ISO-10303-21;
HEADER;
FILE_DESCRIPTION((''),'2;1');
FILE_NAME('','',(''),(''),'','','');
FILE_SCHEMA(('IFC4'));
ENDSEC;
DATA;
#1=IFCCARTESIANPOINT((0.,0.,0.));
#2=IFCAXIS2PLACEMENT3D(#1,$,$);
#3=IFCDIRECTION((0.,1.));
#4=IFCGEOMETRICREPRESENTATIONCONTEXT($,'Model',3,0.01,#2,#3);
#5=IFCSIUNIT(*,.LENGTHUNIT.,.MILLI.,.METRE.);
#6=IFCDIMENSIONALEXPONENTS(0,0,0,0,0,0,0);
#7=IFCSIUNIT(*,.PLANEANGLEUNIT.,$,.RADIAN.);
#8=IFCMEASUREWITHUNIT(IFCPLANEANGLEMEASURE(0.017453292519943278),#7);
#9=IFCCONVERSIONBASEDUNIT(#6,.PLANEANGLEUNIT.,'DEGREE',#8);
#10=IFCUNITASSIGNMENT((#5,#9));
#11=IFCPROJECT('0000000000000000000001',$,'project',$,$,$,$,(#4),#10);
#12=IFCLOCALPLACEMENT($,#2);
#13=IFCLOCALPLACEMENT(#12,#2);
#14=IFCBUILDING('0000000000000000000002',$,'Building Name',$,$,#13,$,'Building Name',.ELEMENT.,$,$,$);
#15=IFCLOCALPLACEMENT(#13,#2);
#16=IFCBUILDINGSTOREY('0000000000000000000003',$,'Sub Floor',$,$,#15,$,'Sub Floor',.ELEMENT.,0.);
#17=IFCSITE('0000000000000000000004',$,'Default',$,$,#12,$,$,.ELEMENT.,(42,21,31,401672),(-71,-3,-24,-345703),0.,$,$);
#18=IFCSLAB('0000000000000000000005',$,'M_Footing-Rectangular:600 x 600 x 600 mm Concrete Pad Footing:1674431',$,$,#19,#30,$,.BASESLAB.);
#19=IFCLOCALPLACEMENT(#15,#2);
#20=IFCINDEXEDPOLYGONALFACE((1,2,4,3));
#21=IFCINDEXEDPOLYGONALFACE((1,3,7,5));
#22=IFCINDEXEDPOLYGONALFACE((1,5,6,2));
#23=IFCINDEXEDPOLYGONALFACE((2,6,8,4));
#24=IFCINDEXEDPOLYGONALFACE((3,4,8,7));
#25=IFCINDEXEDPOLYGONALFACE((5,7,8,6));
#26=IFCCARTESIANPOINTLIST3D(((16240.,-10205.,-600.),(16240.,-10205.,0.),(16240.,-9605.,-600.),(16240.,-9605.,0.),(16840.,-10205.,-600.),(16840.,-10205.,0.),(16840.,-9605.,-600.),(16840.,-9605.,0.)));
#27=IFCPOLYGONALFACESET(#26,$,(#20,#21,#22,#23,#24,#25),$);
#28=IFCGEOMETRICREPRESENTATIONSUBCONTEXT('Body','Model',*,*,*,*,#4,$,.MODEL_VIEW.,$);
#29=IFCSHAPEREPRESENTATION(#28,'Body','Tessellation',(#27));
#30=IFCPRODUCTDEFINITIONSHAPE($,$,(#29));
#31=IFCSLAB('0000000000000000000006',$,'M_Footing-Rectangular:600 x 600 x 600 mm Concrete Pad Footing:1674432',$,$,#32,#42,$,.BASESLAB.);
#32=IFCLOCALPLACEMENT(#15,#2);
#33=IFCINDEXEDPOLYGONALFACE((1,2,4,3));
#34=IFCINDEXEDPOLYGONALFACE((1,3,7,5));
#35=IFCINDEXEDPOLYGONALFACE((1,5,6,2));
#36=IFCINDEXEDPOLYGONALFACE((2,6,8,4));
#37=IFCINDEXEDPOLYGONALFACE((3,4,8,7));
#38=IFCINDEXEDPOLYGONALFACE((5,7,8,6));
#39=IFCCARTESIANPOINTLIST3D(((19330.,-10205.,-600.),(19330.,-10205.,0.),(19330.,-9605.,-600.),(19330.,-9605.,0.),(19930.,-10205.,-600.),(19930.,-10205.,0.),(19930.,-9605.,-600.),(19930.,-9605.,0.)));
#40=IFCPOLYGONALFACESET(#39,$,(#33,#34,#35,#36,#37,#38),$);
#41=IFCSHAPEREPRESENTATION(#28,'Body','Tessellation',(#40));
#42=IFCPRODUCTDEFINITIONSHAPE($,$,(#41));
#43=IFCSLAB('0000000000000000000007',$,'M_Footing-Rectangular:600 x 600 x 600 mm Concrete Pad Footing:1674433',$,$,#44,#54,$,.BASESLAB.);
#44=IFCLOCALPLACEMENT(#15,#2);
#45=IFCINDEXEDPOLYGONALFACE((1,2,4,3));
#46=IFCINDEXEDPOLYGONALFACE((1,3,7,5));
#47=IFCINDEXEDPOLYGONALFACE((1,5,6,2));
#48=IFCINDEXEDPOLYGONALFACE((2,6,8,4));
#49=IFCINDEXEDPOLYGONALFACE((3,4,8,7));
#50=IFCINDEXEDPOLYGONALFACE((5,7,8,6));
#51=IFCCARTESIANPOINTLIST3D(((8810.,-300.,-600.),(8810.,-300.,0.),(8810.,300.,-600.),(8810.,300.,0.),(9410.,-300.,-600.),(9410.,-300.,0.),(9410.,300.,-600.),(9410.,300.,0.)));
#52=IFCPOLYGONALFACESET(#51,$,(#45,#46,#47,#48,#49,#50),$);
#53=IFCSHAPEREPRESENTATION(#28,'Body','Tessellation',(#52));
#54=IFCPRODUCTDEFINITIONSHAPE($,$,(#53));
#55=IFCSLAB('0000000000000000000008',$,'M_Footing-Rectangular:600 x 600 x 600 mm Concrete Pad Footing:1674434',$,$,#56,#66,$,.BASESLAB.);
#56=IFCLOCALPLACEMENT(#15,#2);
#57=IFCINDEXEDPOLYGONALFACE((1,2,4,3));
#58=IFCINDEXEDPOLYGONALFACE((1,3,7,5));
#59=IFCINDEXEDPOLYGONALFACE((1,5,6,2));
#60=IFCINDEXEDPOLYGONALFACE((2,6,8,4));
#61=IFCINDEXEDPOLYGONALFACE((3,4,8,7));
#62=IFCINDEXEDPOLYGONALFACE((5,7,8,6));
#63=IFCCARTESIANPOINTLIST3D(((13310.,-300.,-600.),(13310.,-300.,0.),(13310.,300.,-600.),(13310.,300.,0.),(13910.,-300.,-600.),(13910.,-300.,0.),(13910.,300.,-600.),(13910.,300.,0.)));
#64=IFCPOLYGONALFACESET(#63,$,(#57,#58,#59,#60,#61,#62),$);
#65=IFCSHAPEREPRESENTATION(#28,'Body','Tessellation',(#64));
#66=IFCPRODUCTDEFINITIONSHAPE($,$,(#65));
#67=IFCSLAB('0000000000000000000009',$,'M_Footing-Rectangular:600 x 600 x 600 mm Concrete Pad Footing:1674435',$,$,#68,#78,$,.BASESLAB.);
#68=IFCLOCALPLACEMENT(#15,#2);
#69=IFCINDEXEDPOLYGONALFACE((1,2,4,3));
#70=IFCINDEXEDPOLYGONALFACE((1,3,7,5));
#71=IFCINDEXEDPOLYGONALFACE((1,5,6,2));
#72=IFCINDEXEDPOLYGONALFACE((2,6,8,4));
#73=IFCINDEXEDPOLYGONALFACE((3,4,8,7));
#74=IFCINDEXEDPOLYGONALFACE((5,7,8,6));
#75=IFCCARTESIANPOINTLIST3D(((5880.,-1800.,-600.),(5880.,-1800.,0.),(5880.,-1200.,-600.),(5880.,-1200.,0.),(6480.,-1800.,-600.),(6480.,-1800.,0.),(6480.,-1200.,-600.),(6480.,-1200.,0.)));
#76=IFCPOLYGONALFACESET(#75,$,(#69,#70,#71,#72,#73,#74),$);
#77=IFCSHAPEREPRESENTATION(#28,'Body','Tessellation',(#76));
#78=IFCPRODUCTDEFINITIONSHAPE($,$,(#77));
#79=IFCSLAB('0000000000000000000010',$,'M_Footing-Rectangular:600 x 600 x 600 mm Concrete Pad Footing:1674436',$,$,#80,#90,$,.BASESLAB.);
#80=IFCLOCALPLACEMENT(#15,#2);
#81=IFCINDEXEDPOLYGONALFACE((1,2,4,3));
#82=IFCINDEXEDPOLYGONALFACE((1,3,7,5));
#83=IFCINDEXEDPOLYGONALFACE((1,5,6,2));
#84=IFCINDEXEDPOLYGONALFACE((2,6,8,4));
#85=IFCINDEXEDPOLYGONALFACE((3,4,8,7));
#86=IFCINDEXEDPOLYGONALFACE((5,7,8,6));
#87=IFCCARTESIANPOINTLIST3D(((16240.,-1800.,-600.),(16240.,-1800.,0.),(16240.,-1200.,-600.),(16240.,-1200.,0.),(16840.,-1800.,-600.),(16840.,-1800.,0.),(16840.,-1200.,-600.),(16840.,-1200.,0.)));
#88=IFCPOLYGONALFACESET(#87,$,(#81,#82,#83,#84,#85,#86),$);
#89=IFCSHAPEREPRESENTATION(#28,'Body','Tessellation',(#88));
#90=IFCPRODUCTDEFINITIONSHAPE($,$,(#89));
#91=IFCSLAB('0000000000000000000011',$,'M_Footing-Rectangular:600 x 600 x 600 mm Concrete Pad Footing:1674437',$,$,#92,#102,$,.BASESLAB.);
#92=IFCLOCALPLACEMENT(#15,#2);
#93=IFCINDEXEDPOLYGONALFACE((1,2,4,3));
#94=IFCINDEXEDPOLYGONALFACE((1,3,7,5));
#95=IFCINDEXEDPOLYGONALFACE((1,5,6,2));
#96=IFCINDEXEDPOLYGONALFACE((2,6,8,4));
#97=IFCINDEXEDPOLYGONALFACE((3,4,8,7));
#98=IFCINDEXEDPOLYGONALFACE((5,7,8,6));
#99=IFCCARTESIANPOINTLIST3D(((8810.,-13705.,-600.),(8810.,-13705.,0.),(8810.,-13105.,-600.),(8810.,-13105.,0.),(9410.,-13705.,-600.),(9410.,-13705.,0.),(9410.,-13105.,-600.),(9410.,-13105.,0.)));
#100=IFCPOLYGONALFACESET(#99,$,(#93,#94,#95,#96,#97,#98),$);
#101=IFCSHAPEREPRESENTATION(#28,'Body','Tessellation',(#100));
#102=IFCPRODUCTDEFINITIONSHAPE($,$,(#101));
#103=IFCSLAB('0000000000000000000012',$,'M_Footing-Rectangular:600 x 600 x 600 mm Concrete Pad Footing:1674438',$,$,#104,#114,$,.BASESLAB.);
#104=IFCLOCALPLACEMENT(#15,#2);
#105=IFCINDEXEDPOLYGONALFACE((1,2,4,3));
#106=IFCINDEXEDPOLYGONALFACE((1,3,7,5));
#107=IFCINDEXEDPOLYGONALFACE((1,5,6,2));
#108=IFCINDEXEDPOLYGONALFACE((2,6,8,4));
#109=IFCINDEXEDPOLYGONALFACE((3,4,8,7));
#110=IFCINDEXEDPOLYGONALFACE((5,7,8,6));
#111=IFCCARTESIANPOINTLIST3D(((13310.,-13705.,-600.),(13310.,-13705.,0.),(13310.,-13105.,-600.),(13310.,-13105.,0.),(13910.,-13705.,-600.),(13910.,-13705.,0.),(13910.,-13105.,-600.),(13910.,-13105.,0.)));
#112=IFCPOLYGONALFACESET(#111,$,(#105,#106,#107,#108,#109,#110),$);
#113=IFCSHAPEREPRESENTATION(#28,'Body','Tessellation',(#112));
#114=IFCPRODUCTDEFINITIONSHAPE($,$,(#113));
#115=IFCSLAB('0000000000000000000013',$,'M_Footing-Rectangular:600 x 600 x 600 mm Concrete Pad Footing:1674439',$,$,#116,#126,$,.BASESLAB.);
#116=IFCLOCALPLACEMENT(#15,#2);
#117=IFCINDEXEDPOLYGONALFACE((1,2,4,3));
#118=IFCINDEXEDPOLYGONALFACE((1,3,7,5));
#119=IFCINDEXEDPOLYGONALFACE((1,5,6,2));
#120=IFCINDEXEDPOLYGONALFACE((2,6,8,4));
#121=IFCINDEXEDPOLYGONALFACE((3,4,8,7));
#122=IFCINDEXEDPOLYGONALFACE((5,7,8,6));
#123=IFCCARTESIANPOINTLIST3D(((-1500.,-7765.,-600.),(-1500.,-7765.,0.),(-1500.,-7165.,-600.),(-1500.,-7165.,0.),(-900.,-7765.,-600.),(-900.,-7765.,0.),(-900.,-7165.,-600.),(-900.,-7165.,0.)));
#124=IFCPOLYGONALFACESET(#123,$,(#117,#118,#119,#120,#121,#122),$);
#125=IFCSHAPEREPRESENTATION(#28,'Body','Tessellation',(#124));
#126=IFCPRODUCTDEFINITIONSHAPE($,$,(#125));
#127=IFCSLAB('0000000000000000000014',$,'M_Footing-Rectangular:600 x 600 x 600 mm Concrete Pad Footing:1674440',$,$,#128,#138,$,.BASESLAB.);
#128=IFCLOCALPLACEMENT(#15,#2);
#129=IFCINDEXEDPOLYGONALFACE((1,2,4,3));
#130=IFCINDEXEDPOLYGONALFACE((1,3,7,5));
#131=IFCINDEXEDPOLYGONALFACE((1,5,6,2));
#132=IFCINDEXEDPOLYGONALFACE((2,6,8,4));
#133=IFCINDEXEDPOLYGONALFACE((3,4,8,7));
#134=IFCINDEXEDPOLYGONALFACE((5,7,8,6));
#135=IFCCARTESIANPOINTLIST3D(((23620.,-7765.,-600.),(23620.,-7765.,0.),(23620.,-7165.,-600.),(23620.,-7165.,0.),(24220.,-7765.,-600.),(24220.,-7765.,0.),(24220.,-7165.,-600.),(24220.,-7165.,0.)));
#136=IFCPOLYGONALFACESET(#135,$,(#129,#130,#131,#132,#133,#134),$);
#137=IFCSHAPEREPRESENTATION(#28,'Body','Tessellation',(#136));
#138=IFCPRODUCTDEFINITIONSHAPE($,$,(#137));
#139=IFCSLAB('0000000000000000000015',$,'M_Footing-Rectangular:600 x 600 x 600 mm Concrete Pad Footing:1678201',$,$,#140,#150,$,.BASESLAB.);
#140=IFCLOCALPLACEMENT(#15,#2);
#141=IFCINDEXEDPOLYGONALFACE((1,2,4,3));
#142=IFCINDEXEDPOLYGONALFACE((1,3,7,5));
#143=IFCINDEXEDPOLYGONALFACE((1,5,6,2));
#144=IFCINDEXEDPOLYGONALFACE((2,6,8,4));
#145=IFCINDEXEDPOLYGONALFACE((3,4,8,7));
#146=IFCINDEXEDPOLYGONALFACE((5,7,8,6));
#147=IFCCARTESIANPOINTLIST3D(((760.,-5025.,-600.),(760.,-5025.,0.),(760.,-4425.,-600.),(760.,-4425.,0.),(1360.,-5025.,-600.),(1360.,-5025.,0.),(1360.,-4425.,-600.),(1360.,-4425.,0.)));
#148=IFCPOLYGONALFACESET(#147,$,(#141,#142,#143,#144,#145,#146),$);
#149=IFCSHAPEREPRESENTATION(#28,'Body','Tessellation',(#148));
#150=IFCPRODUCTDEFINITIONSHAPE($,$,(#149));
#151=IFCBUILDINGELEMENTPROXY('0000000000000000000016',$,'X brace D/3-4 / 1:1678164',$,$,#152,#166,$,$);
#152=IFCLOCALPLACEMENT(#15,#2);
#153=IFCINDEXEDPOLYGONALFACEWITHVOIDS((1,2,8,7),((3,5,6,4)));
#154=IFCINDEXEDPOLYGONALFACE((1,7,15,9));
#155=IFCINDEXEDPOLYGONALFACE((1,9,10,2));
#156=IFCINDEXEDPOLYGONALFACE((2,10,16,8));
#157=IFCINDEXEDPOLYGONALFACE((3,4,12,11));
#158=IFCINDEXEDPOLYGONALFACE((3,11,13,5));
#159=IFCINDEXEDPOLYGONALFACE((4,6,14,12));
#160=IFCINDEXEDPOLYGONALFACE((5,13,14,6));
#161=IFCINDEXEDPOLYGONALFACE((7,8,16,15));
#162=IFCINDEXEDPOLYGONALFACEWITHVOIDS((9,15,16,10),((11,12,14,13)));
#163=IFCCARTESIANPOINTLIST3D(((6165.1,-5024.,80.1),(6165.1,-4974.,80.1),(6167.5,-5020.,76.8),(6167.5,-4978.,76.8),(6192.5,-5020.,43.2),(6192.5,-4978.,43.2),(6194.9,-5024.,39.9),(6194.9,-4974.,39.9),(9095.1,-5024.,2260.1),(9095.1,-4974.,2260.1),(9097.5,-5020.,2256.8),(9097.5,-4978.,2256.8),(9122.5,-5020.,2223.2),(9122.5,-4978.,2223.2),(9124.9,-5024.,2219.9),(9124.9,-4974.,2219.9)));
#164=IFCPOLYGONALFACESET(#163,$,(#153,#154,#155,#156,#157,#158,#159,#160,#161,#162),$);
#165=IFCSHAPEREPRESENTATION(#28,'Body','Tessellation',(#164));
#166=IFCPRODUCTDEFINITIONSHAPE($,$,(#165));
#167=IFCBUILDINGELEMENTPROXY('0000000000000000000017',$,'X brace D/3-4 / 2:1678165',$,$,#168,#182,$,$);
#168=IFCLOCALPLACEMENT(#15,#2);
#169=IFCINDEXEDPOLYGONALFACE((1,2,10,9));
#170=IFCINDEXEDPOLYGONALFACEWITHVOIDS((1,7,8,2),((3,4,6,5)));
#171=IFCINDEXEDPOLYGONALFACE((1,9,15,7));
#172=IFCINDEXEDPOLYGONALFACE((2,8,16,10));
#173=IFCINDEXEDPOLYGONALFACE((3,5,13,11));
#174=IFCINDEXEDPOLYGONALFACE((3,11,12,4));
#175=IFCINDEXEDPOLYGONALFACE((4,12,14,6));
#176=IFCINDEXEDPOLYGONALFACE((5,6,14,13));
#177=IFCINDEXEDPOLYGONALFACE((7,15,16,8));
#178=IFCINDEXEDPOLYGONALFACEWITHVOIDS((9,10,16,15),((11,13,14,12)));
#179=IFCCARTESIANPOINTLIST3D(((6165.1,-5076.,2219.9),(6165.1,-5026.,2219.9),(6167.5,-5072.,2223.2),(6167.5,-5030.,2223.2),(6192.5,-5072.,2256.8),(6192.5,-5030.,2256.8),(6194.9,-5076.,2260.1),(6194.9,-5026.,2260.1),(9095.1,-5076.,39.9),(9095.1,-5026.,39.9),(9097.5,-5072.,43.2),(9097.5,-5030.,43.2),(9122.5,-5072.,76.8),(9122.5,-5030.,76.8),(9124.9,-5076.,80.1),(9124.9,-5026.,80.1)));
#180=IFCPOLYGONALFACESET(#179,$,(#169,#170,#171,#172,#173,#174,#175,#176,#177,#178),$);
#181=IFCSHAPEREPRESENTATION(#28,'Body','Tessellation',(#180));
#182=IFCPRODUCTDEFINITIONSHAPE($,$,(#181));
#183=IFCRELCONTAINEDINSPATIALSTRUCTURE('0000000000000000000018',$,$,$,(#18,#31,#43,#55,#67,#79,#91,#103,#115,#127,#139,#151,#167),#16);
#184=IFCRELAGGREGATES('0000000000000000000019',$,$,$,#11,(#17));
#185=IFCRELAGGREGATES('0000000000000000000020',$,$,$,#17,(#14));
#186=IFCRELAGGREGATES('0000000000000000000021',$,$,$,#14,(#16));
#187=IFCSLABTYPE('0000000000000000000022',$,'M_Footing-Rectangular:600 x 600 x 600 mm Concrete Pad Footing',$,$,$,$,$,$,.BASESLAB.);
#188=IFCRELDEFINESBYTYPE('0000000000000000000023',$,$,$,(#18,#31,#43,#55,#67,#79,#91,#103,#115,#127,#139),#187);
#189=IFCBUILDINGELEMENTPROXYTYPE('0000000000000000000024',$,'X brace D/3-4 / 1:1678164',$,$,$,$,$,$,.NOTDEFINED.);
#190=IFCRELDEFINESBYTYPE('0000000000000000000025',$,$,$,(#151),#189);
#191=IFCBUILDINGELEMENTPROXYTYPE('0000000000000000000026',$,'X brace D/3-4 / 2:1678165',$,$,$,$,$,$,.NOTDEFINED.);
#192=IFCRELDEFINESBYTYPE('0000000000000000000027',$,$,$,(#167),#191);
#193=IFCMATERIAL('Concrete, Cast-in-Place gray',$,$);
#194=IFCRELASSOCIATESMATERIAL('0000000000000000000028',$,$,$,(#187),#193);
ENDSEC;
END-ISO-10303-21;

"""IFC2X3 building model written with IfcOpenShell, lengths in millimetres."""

from ifc_helpers import new_model, entity, si_unit, converted_unit, direction, frame, frame_2d, origin, origin_2d_with_axis, place, context, subcontext, project, spatial, polyline, rectangle, outline, extrude, material, type_object, element, save


model = new_model("IFC2X3")

# Units and contexts
model_context = context("Model", 3, precision=0.01, world=origin(), true_north=direction((0.0, 1.0)))
body_context = subcontext(model_context, "Body", "Model", "MODEL_VIEW")
ifc_project = project(units=[si_unit("LENGTHUNIT", "METRE", prefix="MILLI"), converted_unit("PLANEANGLEUNIT", "DEGREE", entity("IfcPlaneAngleMeasure", 0.017453292519943278), si_unit("PLANEANGLEUNIT", "RADIAN"), dimensions=[0, 0, 0, 0, 0, 0, 0])], contexts=[model_context])

# Site, building, storey
site_placement = place(None, origin())
site = spatial("IfcSite", under=ifc_project, at=site_placement, Name="Default", CompositionType="ELEMENT", RefLatitude=(42, 21, 31, 401672), RefLongitude=(-71, -3, -24, -345703), RefElevation=0.0)
building_placement = place(site_placement, origin())
building = spatial("IfcBuilding", under=site, at=building_placement, Name="Building Name", LongName="Building Name", CompositionType="ELEMENT")
storey_placement = place(building_placement, origin())
storey = spatial("IfcBuildingStorey", under=building, at=storey_placement, Name="Sub Floor", LongName="Sub Floor", CompositionType="ELEMENT", Elevation=0.0)

# Slabs
ifc_material_1 = material(Name="Concrete, Cast-in-Place gray")
slab_type_1 = type_object("IfcSlabType", Name="M_Footing-Rectangular:600 x 600 x 600 mm Concrete Pad Footing", PredefinedType="BASESLAB", material=ifc_material_1)
slab_1_placement = place(storey_placement, origin())
element("IfcSlab", 1, at=slab_1_placement, inside=storey, type_object=slab_type_1, Name="M_Footing-Rectangular:600 x 600 x 600 mm Concrete Pad Footing:1674431", PredefinedType="BASESLAB", context=body_context, shape_type="SweptSolid", body=[
    extrude(rectangle(XDim=600.0, YDim=600.0, at=frame_2d((0.0, 0.0), x_axis=(1.0, 0.0))), frame((16540.0, -9905.0, -600.0), z_axis=(0.0, 0.0, 1.0), x_axis=(-1.0, 0.0, 0.0)), (0.0, 0.0, 1.0), 600.0),
])
slab_2_placement = place(storey_placement, origin())
element("IfcSlab", 2, at=slab_2_placement, inside=storey, type_object=slab_type_1, Name="M_Footing-Rectangular:600 x 600 x 600 mm Concrete Pad Footing:1674432", PredefinedType="BASESLAB", context=body_context, shape_type="SweptSolid", body=[
    extrude(rectangle(XDim=600.0, YDim=600.0, at=frame_2d((0.0, 0.0), x_axis=(1.0, 0.0))), frame((19630.0, -9905.0, -600.0), z_axis=(0.0, 0.0, 1.0), x_axis=(-1.0, 0.0, 0.0)), (0.0, 0.0, 1.0), 600.0),
])
slab_3_placement = place(storey_placement, origin())
element("IfcSlab", 3, at=slab_3_placement, inside=storey, type_object=slab_type_1, Name="M_Footing-Rectangular:600 x 600 x 600 mm Concrete Pad Footing:1674433", PredefinedType="BASESLAB", context=body_context, shape_type="SweptSolid", body=[
    extrude(rectangle(XDim=600.0, YDim=600.0, at=origin_2d_with_axis()), frame((9110.0, 0.0, -600.0), z_axis=(0.0, 0.0, 1.0), x_axis=(-1.0, 0.0, 0.0)), (0.0, 0.0, 1.0), 600.0),
])
slab_4_placement = place(storey_placement, origin())
element("IfcSlab", 4, at=slab_4_placement, inside=storey, type_object=slab_type_1, Name="M_Footing-Rectangular:600 x 600 x 600 mm Concrete Pad Footing:1674434", PredefinedType="BASESLAB", context=body_context, shape_type="SweptSolid", body=[
    extrude(rectangle(XDim=600.0, YDim=600.0, at=frame_2d((0.0, 0.0), x_axis=(1.0, 0.0))), frame((13610.0, 0.0, -600.0), z_axis=(0.0, 0.0, 1.0), x_axis=(-1.0, 0.0, 0.0)), (0.0, 0.0, 1.0), 600.0),
])
slab_5_placement = place(storey_placement, origin())
element("IfcSlab", 5, at=slab_5_placement, inside=storey, type_object=slab_type_1, Name="M_Footing-Rectangular:600 x 600 x 600 mm Concrete Pad Footing:1674435", PredefinedType="BASESLAB", context=body_context, shape_type="SweptSolid", body=[
    extrude(rectangle(XDim=600.0, YDim=600.0, at=origin_2d_with_axis()), frame((6180.0, -1500.0, -600.0), z_axis=(0.0, 0.0, 1.0), x_axis=(-1.0, 0.0, 0.0)), (0.0, 0.0, 1.0), 600.0),
])
slab_6_placement = place(storey_placement, origin())
element("IfcSlab", 6, at=slab_6_placement, inside=storey, type_object=slab_type_1, Name="M_Footing-Rectangular:600 x 600 x 600 mm Concrete Pad Footing:1674436", PredefinedType="BASESLAB", context=body_context, shape_type="SweptSolid", body=[
    extrude(rectangle(XDim=600.0, YDim=600.0, at=frame_2d((0.0, 0.0), x_axis=(1.0, 0.0))), frame((16540.0, -1500.0, -600.0), z_axis=(0.0, 0.0, 1.0), x_axis=(-1.0, 0.0, 0.0)), (0.0, 0.0, 1.0), 600.0),
])
slab_7_placement = place(storey_placement, origin())
element("IfcSlab", 7, at=slab_7_placement, inside=storey, type_object=slab_type_1, Name="M_Footing-Rectangular:600 x 600 x 600 mm Concrete Pad Footing:1674437", PredefinedType="BASESLAB", context=body_context, shape_type="SweptSolid", body=[
    extrude(rectangle(XDim=600.0, YDim=600.0, at=frame_2d((0.0, 0.0), x_axis=(1.0, 0.0))), frame((9110.0, -13405.0, -600.0), z_axis=(0.0, 0.0, 1.0), x_axis=(-1.0, 0.0, 0.0)), (0.0, 0.0, 1.0), 600.0),
])
slab_8_placement = place(storey_placement, origin())
element("IfcSlab", 8, at=slab_8_placement, inside=storey, type_object=slab_type_1, Name="M_Footing-Rectangular:600 x 600 x 600 mm Concrete Pad Footing:1674438", PredefinedType="BASESLAB", context=body_context, shape_type="SweptSolid", body=[
    extrude(rectangle(XDim=600.0, YDim=600.0, at=frame_2d((0.0, 0.0), x_axis=(1.0, 0.0))), frame((13610.0, -13405.0, -600.0), z_axis=(0.0, 0.0, 1.0), x_axis=(-1.0, 0.0, 0.0)), (0.0, 0.0, 1.0), 600.0),
])
slab_9_placement = place(storey_placement, origin())
element("IfcSlab", 9, at=slab_9_placement, inside=storey, type_object=slab_type_1, Name="M_Footing-Rectangular:600 x 600 x 600 mm Concrete Pad Footing:1674439", PredefinedType="BASESLAB", context=body_context, shape_type="SweptSolid", body=[
    extrude(rectangle(XDim=600.0, YDim=600.0, at=origin_2d_with_axis()), frame((-1200.0, -7465.0, -600.0), z_axis=(0.0, 0.0, 1.0), x_axis=(-1.0, 0.0, 0.0)), (0.0, 0.0, 1.0), 600.0),
])
slab_10_placement = place(storey_placement, origin())
element("IfcSlab", 10, at=slab_10_placement, inside=storey, type_object=slab_type_1, Name="M_Footing-Rectangular:600 x 600 x 600 mm Concrete Pad Footing:1674440", PredefinedType="BASESLAB", context=body_context, shape_type="SweptSolid", body=[
    extrude(rectangle(XDim=600.0, YDim=600.0, at=frame_2d((0.0, 0.0), x_axis=(1.0, 0.0))), frame((23920.0, -7465.0, -600.0), z_axis=(0.0, 0.0, 1.0), x_axis=(-1.0, 0.0, 0.0)), (0.0, 0.0, 1.0), 600.0),
])
slab_11_placement = place(storey_placement, origin())
element("IfcSlab", 11, at=slab_11_placement, inside=storey, type_object=slab_type_1, Name="M_Footing-Rectangular:600 x 600 x 600 mm Concrete Pad Footing:1678201", PredefinedType="BASESLAB", context=body_context, shape_type="SweptSolid", body=[
    extrude(rectangle(XDim=600.0, YDim=600.0, at=origin_2d_with_axis()), frame((1060.0, -4725.0, -600.0), z_axis=(0.0, 0.0, 1.0), x_axis=(-1.0, 0.0, 0.0)), (0.0, 0.0, 1.0), 600.0),
])

# Building element proxies
building_element_proxy_type_1 = type_object("IfcBuildingElementProxyType", Name="X brace D/3-4 / 1:1678164", PredefinedType="NOTDEFINED")
proxy_1_placement = place(storey_placement, origin())
element("IfcBuildingElementProxy", 12, at=proxy_1_placement, inside=storey, type_object=building_element_proxy_type_1, Name="X brace D/3-4 / 1:1678164", context=body_context, shape_type="SweptSolid", body=[
    extrude(outline(polyline([(-25.0, -25.0), (25.0, -25.0), (25.0, 25.0), (-25.0, 25.0), (-25.0, -25.0)]), holes=[polyline([(-21.0, -21.0), (-21.0, 21.0), (21.0, 21.0), (21.0, -21.0), (-21.0, -21.0)])]), frame((6180.0, -4999.0, 60.0), z_axis=(0.802294, 0.0, 0.596929), x_axis=(0.0, -1.0, 0.0)), (0.0, 0.0, 1.0), 3652.0),
])
building_element_proxy_type_2 = type_object("IfcBuildingElementProxyType", Name="X brace D/3-4 / 2:1678165", PredefinedType="NOTDEFINED")
proxy_2_placement = place(storey_placement, origin())
element("IfcBuildingElementProxy", 13, at=proxy_2_placement, inside=storey, type_object=building_element_proxy_type_2, Name="X brace D/3-4 / 2:1678165", context=body_context, shape_type="SweptSolid", body=[
    extrude(outline(polyline([(-25.0, -25.0), (25.0, -25.0), (25.0, 25.0), (-25.0, 25.0), (-25.0, -25.0)]), holes=[polyline([(-21.0, -21.0), (-21.0, 21.0), (21.0, 21.0), (21.0, -21.0), (-21.0, -21.0)])]), frame((6180.0, -5051.0, 2240.0), z_axis=(0.802294, 0.0, -0.596929), x_axis=(-0.596929, 0.0, -0.802294)), (0.0, 0.0, 1.0), 3652.0),
])

save(model, "model.ifc")
